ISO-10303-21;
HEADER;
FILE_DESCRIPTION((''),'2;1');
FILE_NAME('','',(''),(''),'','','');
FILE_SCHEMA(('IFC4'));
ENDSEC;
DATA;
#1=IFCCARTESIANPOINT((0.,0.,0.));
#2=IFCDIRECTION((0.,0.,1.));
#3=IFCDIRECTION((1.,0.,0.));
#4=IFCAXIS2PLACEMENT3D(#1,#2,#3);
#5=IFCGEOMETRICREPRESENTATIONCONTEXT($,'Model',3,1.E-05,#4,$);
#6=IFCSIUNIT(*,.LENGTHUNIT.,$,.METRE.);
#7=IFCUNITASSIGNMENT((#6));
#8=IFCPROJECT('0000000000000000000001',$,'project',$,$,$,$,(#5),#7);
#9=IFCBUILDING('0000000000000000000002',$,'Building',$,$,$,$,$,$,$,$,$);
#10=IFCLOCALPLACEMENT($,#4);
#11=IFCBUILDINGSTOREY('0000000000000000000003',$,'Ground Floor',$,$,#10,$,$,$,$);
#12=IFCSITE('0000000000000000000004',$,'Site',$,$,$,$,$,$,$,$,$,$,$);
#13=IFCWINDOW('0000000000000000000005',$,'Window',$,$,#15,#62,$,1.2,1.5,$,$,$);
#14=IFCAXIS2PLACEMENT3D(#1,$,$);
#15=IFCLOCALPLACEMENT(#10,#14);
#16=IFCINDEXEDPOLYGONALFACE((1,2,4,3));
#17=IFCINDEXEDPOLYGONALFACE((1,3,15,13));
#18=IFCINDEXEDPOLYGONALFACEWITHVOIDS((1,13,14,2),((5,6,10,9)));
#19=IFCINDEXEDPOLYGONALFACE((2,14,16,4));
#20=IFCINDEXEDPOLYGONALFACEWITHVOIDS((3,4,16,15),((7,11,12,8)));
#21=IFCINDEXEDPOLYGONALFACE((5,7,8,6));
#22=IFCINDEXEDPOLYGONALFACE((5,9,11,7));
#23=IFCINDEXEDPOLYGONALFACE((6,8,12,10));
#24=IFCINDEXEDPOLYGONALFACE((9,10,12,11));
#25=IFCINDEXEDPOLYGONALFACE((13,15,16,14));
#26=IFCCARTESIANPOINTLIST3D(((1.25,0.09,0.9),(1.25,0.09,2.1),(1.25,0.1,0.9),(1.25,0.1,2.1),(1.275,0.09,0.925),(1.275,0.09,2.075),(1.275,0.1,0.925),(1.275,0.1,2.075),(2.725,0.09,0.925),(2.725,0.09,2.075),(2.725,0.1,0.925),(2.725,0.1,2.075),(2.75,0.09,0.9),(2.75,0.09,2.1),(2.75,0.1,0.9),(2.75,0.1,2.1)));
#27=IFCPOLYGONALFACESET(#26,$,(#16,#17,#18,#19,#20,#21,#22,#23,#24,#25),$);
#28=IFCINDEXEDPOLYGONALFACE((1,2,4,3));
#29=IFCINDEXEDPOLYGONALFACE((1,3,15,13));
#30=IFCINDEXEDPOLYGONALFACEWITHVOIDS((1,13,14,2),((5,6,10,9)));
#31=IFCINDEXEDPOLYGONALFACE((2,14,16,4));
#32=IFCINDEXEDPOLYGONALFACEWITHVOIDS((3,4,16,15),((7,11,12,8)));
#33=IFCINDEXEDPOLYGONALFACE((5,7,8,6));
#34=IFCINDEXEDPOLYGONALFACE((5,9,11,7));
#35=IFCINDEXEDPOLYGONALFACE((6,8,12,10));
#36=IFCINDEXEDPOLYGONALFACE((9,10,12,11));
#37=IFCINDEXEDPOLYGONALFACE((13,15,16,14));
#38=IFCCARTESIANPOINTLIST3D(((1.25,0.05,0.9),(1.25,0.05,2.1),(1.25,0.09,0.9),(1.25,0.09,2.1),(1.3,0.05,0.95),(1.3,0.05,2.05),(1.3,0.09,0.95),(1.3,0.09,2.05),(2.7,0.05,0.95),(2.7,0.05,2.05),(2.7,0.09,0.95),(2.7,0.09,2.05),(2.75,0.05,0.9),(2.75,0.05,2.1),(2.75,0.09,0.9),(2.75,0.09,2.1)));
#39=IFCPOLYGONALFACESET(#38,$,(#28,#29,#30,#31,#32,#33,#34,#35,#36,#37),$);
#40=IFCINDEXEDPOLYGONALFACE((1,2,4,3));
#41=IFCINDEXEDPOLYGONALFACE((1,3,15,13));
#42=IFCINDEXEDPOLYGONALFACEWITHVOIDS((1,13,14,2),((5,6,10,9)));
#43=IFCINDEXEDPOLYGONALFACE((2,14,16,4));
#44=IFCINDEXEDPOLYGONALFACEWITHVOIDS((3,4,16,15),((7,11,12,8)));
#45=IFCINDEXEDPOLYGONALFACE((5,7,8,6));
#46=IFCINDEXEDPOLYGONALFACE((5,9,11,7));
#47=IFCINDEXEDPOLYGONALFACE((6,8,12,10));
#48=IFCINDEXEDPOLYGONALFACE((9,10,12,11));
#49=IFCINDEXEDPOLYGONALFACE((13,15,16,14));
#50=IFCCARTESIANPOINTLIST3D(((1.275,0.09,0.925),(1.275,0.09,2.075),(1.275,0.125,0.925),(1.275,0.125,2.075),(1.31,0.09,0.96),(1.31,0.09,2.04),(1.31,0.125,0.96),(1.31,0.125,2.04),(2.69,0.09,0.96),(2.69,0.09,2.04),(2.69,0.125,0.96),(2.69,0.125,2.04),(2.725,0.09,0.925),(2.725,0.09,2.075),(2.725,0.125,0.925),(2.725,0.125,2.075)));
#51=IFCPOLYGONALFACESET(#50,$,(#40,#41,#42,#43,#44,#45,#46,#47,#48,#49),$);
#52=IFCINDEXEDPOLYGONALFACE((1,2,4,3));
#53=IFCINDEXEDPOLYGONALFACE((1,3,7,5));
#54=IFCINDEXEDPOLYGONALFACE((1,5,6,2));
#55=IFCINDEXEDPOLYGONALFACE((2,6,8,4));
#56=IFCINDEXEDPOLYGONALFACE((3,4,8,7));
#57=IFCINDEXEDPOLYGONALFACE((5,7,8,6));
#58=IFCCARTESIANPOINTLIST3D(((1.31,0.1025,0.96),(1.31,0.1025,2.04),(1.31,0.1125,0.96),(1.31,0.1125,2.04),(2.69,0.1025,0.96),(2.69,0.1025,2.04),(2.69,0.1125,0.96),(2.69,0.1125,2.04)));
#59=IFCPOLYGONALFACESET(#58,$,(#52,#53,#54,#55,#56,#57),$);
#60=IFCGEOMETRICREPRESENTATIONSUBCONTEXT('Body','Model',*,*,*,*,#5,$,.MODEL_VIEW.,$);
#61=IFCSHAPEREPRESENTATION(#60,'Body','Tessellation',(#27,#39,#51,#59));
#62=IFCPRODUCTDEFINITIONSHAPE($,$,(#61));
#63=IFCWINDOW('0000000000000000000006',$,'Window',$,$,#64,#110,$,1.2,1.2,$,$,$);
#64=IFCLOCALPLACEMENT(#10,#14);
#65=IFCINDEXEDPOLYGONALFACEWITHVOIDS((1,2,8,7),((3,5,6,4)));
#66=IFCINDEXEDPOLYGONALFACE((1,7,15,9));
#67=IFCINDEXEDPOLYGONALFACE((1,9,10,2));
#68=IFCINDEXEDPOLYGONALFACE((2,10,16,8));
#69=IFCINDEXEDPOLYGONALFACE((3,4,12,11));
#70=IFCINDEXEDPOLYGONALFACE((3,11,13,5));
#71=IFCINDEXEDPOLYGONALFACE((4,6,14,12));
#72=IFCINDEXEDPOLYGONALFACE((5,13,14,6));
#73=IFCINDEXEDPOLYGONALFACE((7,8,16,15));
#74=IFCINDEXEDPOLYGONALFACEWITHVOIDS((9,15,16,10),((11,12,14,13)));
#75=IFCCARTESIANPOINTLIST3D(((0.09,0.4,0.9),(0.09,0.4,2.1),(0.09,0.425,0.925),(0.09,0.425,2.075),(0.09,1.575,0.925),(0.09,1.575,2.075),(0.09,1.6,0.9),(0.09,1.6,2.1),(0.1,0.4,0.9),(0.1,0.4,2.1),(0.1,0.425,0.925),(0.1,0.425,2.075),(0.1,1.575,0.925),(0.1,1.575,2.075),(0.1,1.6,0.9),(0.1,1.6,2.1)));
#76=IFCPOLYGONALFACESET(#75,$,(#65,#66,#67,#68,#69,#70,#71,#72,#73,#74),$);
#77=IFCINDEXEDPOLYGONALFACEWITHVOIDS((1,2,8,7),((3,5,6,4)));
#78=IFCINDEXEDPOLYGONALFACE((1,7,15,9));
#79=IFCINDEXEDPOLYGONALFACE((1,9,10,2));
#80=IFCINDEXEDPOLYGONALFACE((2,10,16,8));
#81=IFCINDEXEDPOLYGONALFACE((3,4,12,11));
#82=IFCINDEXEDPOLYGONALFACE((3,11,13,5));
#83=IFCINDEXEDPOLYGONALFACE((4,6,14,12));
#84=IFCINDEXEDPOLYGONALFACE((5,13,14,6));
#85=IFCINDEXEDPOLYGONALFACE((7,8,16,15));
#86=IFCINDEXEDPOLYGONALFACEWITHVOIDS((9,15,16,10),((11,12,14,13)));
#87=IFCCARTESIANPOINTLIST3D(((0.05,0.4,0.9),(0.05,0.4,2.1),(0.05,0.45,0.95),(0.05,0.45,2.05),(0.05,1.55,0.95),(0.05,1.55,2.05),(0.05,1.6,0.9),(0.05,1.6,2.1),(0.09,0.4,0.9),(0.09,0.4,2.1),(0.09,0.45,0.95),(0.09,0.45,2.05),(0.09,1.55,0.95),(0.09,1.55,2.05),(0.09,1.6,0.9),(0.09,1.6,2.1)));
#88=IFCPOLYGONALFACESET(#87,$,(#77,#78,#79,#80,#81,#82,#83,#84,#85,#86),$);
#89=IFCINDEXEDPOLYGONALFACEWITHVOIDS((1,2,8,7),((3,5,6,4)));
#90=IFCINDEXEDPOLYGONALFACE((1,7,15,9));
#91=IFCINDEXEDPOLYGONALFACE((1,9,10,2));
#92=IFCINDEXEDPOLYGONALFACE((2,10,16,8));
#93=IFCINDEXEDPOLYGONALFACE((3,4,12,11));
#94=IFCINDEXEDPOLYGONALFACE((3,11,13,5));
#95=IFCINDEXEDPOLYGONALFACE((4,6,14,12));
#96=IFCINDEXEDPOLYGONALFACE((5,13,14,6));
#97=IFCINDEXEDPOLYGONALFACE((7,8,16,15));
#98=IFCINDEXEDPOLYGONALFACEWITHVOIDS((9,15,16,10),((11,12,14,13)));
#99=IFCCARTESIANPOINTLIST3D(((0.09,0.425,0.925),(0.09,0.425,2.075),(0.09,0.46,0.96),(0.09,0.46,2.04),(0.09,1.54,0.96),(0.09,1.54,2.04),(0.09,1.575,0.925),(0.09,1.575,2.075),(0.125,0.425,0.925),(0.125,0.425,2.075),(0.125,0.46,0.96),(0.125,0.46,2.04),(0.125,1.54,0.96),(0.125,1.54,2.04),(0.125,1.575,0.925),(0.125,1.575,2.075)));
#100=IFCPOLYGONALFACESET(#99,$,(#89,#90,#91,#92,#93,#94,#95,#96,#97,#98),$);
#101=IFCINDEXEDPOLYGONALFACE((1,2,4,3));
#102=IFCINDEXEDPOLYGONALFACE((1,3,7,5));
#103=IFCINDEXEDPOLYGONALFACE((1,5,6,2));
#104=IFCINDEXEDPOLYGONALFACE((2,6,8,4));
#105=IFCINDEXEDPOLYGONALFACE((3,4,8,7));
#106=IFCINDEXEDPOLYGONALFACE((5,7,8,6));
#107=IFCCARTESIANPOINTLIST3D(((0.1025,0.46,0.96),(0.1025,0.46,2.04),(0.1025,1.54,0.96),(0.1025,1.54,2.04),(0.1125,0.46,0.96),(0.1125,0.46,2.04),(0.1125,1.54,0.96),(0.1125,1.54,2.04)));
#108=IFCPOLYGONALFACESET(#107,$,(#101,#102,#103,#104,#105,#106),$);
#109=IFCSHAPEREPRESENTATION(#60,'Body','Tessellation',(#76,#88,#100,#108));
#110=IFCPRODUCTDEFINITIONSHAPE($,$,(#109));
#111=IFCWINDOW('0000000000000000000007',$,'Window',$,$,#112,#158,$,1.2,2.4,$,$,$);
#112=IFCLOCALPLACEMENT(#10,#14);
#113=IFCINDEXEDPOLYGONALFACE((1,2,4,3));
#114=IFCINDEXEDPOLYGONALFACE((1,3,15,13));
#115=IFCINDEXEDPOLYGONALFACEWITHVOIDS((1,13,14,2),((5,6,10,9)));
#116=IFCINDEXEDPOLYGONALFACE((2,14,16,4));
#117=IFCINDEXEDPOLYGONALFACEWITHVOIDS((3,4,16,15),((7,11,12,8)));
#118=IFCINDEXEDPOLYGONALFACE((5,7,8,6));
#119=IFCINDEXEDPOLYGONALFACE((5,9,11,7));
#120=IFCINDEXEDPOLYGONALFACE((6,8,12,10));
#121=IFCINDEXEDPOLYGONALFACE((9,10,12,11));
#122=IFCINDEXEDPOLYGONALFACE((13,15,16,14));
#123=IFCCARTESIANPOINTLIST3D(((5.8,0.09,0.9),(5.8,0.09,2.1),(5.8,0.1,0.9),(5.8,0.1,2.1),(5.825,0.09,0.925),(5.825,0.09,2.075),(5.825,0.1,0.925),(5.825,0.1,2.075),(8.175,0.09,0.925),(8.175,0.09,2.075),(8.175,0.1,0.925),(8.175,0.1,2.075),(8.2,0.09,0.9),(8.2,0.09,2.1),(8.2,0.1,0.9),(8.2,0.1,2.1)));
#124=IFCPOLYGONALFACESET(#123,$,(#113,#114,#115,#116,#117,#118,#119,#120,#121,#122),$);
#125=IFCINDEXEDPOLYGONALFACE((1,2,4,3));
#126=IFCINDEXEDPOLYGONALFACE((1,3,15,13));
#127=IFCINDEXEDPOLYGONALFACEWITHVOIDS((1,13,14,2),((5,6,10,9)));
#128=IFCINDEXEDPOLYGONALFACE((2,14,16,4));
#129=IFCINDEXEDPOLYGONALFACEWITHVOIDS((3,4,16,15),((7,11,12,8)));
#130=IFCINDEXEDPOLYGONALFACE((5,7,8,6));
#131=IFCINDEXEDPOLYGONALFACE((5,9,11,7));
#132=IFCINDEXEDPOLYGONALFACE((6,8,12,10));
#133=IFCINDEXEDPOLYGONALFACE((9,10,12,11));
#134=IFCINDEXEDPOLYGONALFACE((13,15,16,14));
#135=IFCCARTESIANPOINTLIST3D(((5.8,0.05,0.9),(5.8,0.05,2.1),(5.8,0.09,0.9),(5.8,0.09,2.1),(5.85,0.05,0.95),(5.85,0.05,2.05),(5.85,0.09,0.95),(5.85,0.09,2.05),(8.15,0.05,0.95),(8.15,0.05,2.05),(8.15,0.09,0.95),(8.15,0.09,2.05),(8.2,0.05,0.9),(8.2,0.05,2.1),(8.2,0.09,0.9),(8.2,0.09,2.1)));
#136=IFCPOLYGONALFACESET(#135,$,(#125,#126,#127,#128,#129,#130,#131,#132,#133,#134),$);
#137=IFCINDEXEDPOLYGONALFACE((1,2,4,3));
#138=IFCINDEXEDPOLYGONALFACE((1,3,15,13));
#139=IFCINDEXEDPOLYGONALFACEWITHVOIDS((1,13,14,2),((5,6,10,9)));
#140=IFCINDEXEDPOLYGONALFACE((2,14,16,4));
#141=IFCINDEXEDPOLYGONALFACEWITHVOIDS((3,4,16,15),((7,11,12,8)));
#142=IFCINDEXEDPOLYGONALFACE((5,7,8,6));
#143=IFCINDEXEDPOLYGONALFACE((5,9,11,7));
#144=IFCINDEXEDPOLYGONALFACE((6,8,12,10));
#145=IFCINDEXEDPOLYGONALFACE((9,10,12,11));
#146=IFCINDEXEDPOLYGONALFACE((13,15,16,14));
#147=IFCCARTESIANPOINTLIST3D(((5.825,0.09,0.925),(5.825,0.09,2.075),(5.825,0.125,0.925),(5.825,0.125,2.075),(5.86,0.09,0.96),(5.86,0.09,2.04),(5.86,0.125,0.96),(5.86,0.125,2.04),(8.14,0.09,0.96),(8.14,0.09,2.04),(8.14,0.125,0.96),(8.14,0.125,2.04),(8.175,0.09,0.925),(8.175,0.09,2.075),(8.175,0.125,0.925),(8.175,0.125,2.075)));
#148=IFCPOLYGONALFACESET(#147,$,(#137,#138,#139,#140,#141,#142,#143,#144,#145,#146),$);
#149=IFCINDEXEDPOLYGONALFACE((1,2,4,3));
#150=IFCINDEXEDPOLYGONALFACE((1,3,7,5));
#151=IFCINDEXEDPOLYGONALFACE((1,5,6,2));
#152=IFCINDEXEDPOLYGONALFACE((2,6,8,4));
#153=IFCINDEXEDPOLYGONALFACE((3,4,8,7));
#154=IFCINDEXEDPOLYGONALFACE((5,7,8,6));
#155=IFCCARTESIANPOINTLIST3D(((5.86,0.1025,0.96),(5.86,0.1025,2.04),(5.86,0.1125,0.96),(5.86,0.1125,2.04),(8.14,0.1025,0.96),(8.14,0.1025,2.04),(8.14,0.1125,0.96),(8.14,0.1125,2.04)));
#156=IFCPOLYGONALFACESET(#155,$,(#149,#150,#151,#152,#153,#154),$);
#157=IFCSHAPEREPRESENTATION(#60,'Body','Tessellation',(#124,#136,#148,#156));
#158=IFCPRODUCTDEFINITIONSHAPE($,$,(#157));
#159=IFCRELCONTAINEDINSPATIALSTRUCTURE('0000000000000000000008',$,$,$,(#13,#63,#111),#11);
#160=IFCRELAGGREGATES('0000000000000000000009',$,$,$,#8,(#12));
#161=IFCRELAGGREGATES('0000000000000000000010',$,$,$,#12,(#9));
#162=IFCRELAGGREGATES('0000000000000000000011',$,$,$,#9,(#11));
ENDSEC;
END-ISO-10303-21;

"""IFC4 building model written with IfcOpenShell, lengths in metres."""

from ifc_helpers import new_model, si_unit, frame, origin_with_axes, place, context, subcontext, project, spatial, line, indexed_curve, outline, extrude, element, save


model = new_model("IFC4")

# Units and contexts
model_context = context("Model", 3, precision=1e-05, world=origin_with_axes())
body_context = subcontext(model_context, "Body", "Model", "MODEL_VIEW")
ifc_project = project(units=[si_unit("LENGTHUNIT", "METRE")], contexts=[model_context])

# Site, building, storey
site = spatial("IfcSite", under=ifc_project, Name="Site")
building = spatial("IfcBuilding", under=site, Name="Building")
storey_placement = place(None, origin_with_axes())
storey = spatial("IfcBuildingStorey", under=building, at=storey_placement, Name="Ground Floor")

# Windows
window_1_placement = place(storey_placement, frame((1.25, 0.0, 0.9), z_axis=(0.0, 0.0, 1.0), x_axis=(1.0, 0.0, 0.0)))
element("IfcWindow", 1, at=window_1_placement, inside=storey, Name="Window", OverallHeight=1.2, OverallWidth=1.5, context=body_context, shape_type="SweptSolid", body=[
    extrude(outline(indexed_curve([(0.0, 0.0), (1.5, 0.0), (1.5, 1.2), (0.0, 1.2)], segments=[line(1, 2, 3, 4, 1)]), holes=[indexed_curve([(0.025, 0.025), (1.475, 0.025), (1.475, 1.175), (0.025, 1.175)], segments=[line(1, 2, 3, 4, 1)])]), frame((0.0, 0.09, 0.0), z_axis=(0.0, -1.0, 0.0), x_axis=(1.0, 0.0, 0.0)), (0.0, 0.0, -1.0), 0.01),
    extrude(outline(indexed_curve([(0.0, 0.0), (1.5, 0.0), (1.5, 1.2), (0.0, 1.2)], segments=[line(1, 2, 3, 4, 1)]), holes=[indexed_curve([(0.05, 0.05), (1.45, 0.05), (1.45, 1.15), (0.05, 1.15)], segments=[line(1, 2, 3, 4, 1)])]), frame((0.0, 0.05, 0.0), z_axis=(0.0, -1.0, 0.0), x_axis=(1.0, 0.0, 0.0)), (0.0, 0.0, -1.0), 0.04),
    extrude(outline(indexed_curve([(0.0, 0.0), (1.45, 0.0), (1.45, 1.15), (0.0, 1.15)], segments=[line(1, 2, 3, 4, 1)]), holes=[indexed_curve([(0.035, 0.035), (1.415, 0.035), (1.415, 1.115), (0.035, 1.115)], segments=[line(1, 2, 3, 4, 1)])]), frame((0.025, 0.09, 0.025), z_axis=(0.0, -1.0, 0.0), x_axis=(1.0, 0.0, 0.0)), (0.0, 0.0, -1.0), 0.035),
    extrude(outline(indexed_curve([(0.035, 0.035), (1.415, 0.035), (1.415, 1.115), (0.035, 1.115)], segments=[line(1, 2, 3, 4, 1)])), frame((0.025, 0.1025, 0.025), z_axis=(0.0, -1.0, 0.0), x_axis=(1.0, 0.0, 0.0)), (0.0, 0.0, -1.0), 0.01),
])
window_2_placement = place(storey_placement, frame((0.0, 1.6, 0.9), z_axis=(0.0, 0.0, 1.0), x_axis=(0.0, -1.0, 0.0)))
element("IfcWindow", 2, at=window_2_placement, inside=storey, Name="Window", OverallHeight=1.2, OverallWidth=1.2, context=body_context, shape_type="SweptSolid", body=[
    extrude(outline(indexed_curve([(0.0, 0.0), (1.2, 0.0), (1.2, 1.2), (0.0, 1.2)], segments=[line(1, 2, 3, 4, 1)]), holes=[indexed_curve([(0.025, 0.025), (1.175, 0.025), (1.175, 1.175), (0.025, 1.175)], segments=[line(1, 2, 3, 4, 1)])]), frame((0.0, 0.09, 0.0), z_axis=(0.0, -1.0, 0.0), x_axis=(1.0, 0.0, 0.0)), (0.0, 0.0, -1.0), 0.01),
    extrude(outline(indexed_curve([(0.0, 0.0), (1.2, 0.0), (1.2, 1.2), (0.0, 1.2)], segments=[line(1, 2, 3, 4, 1)]), holes=[indexed_curve([(0.05, 0.05), (1.15, 0.05), (1.15, 1.15), (0.05, 1.15)], segments=[line(1, 2, 3, 4, 1)])]), frame((0.0, 0.05, 0.0), z_axis=(0.0, -1.0, 0.0), x_axis=(1.0, 0.0, 0.0)), (0.0, 0.0, -1.0), 0.04),
    extrude(outline(indexed_curve([(0.0, 0.0), (1.15, 0.0), (1.15, 1.15), (0.0, 1.15)], segments=[line(1, 2, 3, 4, 1)]), holes=[indexed_curve([(0.035, 0.035), (1.115, 0.035), (1.115, 1.115), (0.035, 1.115)], segments=[line(1, 2, 3, 4, 1)])]), frame((0.025, 0.09, 0.025), z_axis=(0.0, -1.0, 0.0), x_axis=(1.0, 0.0, 0.0)), (0.0, 0.0, -1.0), 0.035),
    extrude(outline(indexed_curve([(0.035, 0.035), (1.115, 0.035), (1.115, 1.115), (0.035, 1.115)], segments=[line(1, 2, 3, 4, 1)])), frame((0.025, 0.1025, 0.025), z_axis=(0.0, -1.0, 0.0), x_axis=(1.0, 0.0, 0.0)), (0.0, 0.0, -1.0), 0.01),
])
window_3_placement = place(storey_placement, frame((5.8, 0.0, 0.9), z_axis=(0.0, 0.0, 1.0), x_axis=(1.0, 0.0, 0.0)))
element("IfcWindow", 3, at=window_3_placement, inside=storey, Name="Window", OverallHeight=1.2, OverallWidth=2.4, context=body_context, shape_type="SweptSolid", body=[
    extrude(outline(indexed_curve([(0.0, 0.0), (2.4, 0.0), (2.4, 1.2), (0.0, 1.2)], segments=[line(1, 2, 3, 4, 1)]), holes=[indexed_curve([(0.025, 0.025), (2.375, 0.025), (2.375, 1.175), (0.025, 1.175)], segments=[line(1, 2, 3, 4, 1)])]), frame((0.0, 0.09, 0.0), z_axis=(0.0, -1.0, 0.0), x_axis=(1.0, 0.0, 0.0)), (0.0, 0.0, -1.0), 0.01),
    extrude(outline(indexed_curve([(0.0, 0.0), (2.4, 0.0), (2.4, 1.2), (0.0, 1.2)], segments=[line(1, 2, 3, 4, 1)]), holes=[indexed_curve([(0.05, 0.05), (2.35, 0.05), (2.35, 1.15), (0.05, 1.15)], segments=[line(1, 2, 3, 4, 1)])]), frame((0.0, 0.05, 0.0), z_axis=(0.0, -1.0, 0.0), x_axis=(1.0, 0.0, 0.0)), (0.0, 0.0, -1.0), 0.04),
    extrude(outline(indexed_curve([(0.0, 0.0), (2.35, 0.0), (2.35, 1.15), (0.0, 1.15)], segments=[line(1, 2, 3, 4, 1)]), holes=[indexed_curve([(0.035, 0.035), (2.315, 0.035), (2.315, 1.115), (0.035, 1.115)], segments=[line(1, 2, 3, 4, 1)])]), frame((0.025, 0.09, 0.025), z_axis=(0.0, -1.0, 0.0), x_axis=(1.0, 0.0, 0.0)), (0.0, 0.0, -1.0), 0.035),
    extrude(outline(indexed_curve([(0.035, 0.035), (2.315, 0.035), (2.315, 1.115), (0.035, 1.115)], segments=[line(1, 2, 3, 4, 1)])), frame((0.025, 0.1025, 0.025), z_axis=(0.0, -1.0, 0.0), x_axis=(1.0, 0.0, 0.0)), (0.0, 0.0, -1.0), 0.01),
])

save(model, "model.ifc")
